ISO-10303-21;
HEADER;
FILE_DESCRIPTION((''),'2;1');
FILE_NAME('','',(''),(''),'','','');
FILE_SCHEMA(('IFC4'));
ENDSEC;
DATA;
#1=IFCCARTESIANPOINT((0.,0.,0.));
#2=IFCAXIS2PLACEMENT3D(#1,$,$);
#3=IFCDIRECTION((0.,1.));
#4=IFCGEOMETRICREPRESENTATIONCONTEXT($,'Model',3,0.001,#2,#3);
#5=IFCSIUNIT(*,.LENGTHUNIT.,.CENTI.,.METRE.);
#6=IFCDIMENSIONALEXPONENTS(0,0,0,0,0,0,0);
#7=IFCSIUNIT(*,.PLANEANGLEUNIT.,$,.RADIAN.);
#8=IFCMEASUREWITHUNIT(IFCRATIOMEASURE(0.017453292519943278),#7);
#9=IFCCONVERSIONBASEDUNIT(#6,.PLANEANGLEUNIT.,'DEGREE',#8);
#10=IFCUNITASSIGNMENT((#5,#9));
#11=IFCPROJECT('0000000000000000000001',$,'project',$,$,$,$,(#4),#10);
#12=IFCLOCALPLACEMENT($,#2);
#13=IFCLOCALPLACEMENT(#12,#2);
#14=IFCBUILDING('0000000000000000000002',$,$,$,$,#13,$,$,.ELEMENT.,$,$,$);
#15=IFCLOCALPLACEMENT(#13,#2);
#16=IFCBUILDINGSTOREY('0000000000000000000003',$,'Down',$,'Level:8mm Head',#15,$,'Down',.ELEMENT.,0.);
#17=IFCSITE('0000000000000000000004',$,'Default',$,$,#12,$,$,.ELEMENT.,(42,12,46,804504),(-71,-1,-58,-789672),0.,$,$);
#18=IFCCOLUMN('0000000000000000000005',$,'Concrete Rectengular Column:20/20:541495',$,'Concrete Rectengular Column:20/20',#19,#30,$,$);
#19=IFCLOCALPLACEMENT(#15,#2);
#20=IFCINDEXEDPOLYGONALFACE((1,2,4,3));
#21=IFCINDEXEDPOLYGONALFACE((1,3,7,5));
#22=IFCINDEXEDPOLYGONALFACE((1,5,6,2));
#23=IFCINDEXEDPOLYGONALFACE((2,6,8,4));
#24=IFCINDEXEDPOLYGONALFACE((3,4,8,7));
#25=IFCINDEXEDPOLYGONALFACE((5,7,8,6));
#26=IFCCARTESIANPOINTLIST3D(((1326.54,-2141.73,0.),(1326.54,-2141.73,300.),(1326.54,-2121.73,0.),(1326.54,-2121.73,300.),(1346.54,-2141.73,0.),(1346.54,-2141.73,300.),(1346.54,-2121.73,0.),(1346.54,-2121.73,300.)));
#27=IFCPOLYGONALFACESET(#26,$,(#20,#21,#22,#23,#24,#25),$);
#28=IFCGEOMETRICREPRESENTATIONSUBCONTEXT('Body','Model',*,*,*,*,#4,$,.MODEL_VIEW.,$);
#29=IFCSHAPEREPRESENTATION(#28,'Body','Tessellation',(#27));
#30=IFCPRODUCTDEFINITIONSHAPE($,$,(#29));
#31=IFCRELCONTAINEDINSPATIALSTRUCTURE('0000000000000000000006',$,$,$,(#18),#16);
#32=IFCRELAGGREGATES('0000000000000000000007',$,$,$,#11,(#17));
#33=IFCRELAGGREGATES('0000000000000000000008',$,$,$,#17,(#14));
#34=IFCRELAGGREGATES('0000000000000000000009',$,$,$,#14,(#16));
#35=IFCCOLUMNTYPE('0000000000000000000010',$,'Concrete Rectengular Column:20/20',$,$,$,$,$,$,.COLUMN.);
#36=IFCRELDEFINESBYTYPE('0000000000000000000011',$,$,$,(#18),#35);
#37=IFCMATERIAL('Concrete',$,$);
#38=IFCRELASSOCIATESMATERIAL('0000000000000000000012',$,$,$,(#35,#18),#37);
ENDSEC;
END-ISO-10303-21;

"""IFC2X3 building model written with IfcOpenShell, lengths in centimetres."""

from ifc_helpers import new_model, entity, si_unit, converted_unit, direction, frame, frame_2d, origin, place, context, subcontext, project, spatial, rectangle, extrude, source, transform, mapped, material, type_object, type_shapes, element, save


model = new_model("IFC2X3")

# Units and contexts
model_context = context("Model", 3, precision=0.001, world=origin(), true_north=direction((0.0, 1.0)))
body_context = subcontext(model_context, "Body", "Model", "MODEL_VIEW")
ifc_project = project(units=[si_unit("LENGTHUNIT", "METRE", prefix="CENTI"), converted_unit("PLANEANGLEUNIT", "DEGREE", entity("IfcRatioMeasure", 0.017453292519943278), si_unit("PLANEANGLEUNIT", "RADIAN"), dimensions=[0, 0, 0, 0, 0, 0, 0])], contexts=[model_context])

# Site, building, storey
site_placement = place(None, origin())
site = spatial("IfcSite", under=ifc_project, at=site_placement, Name="Default", CompositionType="ELEMENT", RefLatitude=(42, 12, 46, 804504), RefLongitude=(-71, -1, -58, -789672), RefElevation=0.0)
building_placement = place(site_placement, origin())
building = spatial("IfcBuilding", under=site, at=building_placement, CompositionType="ELEMENT")
storey_placement = place(building_placement, origin())
storey = spatial("IfcBuildingStorey", under=building, at=storey_placement, Name="Down", ObjectType="Level:8mm Head", LongName="Down", CompositionType="ELEMENT", Elevation=0.0)

# Column
ifc_material = material(Name="Concrete")
column_type_1 = type_object("IfcColumnType", Name="Concrete Rectengular Column:20/20", PredefinedType="COLUMN", material=ifc_material)
shared_shape_1 = source(origin(), body_context, "Body", "SweptSolid", [
    extrude(rectangle(XDim=20.0, YDim=20.0, at=frame_2d((0.0, 0.0), x_axis=(1.0, 0.0))), frame((1336.54, -2131.73, 0.0), z_axis=(0.0, 0.0, 1.0), x_axis=(0.0, -1.0, 0.0)), (0.0, 0.0, 1.0), 300.0),
])
type_shapes(column_type_1, [shared_shape_1])
column_1_placement = place(storey_placement, origin())
element("IfcColumn", 1, at=column_1_placement, inside=storey, type_object=column_type_1, material=ifc_material, Name="Concrete Rectengular Column:20/20:541495", ObjectType="Concrete Rectengular Column:20/20", context=body_context, shape_type="MappedRepresentation", body=[
    mapped(shared_shape_1, transform((0.0, 0.0, 0.0), scale=1.0)),
])

save(model, "model.ifc")
